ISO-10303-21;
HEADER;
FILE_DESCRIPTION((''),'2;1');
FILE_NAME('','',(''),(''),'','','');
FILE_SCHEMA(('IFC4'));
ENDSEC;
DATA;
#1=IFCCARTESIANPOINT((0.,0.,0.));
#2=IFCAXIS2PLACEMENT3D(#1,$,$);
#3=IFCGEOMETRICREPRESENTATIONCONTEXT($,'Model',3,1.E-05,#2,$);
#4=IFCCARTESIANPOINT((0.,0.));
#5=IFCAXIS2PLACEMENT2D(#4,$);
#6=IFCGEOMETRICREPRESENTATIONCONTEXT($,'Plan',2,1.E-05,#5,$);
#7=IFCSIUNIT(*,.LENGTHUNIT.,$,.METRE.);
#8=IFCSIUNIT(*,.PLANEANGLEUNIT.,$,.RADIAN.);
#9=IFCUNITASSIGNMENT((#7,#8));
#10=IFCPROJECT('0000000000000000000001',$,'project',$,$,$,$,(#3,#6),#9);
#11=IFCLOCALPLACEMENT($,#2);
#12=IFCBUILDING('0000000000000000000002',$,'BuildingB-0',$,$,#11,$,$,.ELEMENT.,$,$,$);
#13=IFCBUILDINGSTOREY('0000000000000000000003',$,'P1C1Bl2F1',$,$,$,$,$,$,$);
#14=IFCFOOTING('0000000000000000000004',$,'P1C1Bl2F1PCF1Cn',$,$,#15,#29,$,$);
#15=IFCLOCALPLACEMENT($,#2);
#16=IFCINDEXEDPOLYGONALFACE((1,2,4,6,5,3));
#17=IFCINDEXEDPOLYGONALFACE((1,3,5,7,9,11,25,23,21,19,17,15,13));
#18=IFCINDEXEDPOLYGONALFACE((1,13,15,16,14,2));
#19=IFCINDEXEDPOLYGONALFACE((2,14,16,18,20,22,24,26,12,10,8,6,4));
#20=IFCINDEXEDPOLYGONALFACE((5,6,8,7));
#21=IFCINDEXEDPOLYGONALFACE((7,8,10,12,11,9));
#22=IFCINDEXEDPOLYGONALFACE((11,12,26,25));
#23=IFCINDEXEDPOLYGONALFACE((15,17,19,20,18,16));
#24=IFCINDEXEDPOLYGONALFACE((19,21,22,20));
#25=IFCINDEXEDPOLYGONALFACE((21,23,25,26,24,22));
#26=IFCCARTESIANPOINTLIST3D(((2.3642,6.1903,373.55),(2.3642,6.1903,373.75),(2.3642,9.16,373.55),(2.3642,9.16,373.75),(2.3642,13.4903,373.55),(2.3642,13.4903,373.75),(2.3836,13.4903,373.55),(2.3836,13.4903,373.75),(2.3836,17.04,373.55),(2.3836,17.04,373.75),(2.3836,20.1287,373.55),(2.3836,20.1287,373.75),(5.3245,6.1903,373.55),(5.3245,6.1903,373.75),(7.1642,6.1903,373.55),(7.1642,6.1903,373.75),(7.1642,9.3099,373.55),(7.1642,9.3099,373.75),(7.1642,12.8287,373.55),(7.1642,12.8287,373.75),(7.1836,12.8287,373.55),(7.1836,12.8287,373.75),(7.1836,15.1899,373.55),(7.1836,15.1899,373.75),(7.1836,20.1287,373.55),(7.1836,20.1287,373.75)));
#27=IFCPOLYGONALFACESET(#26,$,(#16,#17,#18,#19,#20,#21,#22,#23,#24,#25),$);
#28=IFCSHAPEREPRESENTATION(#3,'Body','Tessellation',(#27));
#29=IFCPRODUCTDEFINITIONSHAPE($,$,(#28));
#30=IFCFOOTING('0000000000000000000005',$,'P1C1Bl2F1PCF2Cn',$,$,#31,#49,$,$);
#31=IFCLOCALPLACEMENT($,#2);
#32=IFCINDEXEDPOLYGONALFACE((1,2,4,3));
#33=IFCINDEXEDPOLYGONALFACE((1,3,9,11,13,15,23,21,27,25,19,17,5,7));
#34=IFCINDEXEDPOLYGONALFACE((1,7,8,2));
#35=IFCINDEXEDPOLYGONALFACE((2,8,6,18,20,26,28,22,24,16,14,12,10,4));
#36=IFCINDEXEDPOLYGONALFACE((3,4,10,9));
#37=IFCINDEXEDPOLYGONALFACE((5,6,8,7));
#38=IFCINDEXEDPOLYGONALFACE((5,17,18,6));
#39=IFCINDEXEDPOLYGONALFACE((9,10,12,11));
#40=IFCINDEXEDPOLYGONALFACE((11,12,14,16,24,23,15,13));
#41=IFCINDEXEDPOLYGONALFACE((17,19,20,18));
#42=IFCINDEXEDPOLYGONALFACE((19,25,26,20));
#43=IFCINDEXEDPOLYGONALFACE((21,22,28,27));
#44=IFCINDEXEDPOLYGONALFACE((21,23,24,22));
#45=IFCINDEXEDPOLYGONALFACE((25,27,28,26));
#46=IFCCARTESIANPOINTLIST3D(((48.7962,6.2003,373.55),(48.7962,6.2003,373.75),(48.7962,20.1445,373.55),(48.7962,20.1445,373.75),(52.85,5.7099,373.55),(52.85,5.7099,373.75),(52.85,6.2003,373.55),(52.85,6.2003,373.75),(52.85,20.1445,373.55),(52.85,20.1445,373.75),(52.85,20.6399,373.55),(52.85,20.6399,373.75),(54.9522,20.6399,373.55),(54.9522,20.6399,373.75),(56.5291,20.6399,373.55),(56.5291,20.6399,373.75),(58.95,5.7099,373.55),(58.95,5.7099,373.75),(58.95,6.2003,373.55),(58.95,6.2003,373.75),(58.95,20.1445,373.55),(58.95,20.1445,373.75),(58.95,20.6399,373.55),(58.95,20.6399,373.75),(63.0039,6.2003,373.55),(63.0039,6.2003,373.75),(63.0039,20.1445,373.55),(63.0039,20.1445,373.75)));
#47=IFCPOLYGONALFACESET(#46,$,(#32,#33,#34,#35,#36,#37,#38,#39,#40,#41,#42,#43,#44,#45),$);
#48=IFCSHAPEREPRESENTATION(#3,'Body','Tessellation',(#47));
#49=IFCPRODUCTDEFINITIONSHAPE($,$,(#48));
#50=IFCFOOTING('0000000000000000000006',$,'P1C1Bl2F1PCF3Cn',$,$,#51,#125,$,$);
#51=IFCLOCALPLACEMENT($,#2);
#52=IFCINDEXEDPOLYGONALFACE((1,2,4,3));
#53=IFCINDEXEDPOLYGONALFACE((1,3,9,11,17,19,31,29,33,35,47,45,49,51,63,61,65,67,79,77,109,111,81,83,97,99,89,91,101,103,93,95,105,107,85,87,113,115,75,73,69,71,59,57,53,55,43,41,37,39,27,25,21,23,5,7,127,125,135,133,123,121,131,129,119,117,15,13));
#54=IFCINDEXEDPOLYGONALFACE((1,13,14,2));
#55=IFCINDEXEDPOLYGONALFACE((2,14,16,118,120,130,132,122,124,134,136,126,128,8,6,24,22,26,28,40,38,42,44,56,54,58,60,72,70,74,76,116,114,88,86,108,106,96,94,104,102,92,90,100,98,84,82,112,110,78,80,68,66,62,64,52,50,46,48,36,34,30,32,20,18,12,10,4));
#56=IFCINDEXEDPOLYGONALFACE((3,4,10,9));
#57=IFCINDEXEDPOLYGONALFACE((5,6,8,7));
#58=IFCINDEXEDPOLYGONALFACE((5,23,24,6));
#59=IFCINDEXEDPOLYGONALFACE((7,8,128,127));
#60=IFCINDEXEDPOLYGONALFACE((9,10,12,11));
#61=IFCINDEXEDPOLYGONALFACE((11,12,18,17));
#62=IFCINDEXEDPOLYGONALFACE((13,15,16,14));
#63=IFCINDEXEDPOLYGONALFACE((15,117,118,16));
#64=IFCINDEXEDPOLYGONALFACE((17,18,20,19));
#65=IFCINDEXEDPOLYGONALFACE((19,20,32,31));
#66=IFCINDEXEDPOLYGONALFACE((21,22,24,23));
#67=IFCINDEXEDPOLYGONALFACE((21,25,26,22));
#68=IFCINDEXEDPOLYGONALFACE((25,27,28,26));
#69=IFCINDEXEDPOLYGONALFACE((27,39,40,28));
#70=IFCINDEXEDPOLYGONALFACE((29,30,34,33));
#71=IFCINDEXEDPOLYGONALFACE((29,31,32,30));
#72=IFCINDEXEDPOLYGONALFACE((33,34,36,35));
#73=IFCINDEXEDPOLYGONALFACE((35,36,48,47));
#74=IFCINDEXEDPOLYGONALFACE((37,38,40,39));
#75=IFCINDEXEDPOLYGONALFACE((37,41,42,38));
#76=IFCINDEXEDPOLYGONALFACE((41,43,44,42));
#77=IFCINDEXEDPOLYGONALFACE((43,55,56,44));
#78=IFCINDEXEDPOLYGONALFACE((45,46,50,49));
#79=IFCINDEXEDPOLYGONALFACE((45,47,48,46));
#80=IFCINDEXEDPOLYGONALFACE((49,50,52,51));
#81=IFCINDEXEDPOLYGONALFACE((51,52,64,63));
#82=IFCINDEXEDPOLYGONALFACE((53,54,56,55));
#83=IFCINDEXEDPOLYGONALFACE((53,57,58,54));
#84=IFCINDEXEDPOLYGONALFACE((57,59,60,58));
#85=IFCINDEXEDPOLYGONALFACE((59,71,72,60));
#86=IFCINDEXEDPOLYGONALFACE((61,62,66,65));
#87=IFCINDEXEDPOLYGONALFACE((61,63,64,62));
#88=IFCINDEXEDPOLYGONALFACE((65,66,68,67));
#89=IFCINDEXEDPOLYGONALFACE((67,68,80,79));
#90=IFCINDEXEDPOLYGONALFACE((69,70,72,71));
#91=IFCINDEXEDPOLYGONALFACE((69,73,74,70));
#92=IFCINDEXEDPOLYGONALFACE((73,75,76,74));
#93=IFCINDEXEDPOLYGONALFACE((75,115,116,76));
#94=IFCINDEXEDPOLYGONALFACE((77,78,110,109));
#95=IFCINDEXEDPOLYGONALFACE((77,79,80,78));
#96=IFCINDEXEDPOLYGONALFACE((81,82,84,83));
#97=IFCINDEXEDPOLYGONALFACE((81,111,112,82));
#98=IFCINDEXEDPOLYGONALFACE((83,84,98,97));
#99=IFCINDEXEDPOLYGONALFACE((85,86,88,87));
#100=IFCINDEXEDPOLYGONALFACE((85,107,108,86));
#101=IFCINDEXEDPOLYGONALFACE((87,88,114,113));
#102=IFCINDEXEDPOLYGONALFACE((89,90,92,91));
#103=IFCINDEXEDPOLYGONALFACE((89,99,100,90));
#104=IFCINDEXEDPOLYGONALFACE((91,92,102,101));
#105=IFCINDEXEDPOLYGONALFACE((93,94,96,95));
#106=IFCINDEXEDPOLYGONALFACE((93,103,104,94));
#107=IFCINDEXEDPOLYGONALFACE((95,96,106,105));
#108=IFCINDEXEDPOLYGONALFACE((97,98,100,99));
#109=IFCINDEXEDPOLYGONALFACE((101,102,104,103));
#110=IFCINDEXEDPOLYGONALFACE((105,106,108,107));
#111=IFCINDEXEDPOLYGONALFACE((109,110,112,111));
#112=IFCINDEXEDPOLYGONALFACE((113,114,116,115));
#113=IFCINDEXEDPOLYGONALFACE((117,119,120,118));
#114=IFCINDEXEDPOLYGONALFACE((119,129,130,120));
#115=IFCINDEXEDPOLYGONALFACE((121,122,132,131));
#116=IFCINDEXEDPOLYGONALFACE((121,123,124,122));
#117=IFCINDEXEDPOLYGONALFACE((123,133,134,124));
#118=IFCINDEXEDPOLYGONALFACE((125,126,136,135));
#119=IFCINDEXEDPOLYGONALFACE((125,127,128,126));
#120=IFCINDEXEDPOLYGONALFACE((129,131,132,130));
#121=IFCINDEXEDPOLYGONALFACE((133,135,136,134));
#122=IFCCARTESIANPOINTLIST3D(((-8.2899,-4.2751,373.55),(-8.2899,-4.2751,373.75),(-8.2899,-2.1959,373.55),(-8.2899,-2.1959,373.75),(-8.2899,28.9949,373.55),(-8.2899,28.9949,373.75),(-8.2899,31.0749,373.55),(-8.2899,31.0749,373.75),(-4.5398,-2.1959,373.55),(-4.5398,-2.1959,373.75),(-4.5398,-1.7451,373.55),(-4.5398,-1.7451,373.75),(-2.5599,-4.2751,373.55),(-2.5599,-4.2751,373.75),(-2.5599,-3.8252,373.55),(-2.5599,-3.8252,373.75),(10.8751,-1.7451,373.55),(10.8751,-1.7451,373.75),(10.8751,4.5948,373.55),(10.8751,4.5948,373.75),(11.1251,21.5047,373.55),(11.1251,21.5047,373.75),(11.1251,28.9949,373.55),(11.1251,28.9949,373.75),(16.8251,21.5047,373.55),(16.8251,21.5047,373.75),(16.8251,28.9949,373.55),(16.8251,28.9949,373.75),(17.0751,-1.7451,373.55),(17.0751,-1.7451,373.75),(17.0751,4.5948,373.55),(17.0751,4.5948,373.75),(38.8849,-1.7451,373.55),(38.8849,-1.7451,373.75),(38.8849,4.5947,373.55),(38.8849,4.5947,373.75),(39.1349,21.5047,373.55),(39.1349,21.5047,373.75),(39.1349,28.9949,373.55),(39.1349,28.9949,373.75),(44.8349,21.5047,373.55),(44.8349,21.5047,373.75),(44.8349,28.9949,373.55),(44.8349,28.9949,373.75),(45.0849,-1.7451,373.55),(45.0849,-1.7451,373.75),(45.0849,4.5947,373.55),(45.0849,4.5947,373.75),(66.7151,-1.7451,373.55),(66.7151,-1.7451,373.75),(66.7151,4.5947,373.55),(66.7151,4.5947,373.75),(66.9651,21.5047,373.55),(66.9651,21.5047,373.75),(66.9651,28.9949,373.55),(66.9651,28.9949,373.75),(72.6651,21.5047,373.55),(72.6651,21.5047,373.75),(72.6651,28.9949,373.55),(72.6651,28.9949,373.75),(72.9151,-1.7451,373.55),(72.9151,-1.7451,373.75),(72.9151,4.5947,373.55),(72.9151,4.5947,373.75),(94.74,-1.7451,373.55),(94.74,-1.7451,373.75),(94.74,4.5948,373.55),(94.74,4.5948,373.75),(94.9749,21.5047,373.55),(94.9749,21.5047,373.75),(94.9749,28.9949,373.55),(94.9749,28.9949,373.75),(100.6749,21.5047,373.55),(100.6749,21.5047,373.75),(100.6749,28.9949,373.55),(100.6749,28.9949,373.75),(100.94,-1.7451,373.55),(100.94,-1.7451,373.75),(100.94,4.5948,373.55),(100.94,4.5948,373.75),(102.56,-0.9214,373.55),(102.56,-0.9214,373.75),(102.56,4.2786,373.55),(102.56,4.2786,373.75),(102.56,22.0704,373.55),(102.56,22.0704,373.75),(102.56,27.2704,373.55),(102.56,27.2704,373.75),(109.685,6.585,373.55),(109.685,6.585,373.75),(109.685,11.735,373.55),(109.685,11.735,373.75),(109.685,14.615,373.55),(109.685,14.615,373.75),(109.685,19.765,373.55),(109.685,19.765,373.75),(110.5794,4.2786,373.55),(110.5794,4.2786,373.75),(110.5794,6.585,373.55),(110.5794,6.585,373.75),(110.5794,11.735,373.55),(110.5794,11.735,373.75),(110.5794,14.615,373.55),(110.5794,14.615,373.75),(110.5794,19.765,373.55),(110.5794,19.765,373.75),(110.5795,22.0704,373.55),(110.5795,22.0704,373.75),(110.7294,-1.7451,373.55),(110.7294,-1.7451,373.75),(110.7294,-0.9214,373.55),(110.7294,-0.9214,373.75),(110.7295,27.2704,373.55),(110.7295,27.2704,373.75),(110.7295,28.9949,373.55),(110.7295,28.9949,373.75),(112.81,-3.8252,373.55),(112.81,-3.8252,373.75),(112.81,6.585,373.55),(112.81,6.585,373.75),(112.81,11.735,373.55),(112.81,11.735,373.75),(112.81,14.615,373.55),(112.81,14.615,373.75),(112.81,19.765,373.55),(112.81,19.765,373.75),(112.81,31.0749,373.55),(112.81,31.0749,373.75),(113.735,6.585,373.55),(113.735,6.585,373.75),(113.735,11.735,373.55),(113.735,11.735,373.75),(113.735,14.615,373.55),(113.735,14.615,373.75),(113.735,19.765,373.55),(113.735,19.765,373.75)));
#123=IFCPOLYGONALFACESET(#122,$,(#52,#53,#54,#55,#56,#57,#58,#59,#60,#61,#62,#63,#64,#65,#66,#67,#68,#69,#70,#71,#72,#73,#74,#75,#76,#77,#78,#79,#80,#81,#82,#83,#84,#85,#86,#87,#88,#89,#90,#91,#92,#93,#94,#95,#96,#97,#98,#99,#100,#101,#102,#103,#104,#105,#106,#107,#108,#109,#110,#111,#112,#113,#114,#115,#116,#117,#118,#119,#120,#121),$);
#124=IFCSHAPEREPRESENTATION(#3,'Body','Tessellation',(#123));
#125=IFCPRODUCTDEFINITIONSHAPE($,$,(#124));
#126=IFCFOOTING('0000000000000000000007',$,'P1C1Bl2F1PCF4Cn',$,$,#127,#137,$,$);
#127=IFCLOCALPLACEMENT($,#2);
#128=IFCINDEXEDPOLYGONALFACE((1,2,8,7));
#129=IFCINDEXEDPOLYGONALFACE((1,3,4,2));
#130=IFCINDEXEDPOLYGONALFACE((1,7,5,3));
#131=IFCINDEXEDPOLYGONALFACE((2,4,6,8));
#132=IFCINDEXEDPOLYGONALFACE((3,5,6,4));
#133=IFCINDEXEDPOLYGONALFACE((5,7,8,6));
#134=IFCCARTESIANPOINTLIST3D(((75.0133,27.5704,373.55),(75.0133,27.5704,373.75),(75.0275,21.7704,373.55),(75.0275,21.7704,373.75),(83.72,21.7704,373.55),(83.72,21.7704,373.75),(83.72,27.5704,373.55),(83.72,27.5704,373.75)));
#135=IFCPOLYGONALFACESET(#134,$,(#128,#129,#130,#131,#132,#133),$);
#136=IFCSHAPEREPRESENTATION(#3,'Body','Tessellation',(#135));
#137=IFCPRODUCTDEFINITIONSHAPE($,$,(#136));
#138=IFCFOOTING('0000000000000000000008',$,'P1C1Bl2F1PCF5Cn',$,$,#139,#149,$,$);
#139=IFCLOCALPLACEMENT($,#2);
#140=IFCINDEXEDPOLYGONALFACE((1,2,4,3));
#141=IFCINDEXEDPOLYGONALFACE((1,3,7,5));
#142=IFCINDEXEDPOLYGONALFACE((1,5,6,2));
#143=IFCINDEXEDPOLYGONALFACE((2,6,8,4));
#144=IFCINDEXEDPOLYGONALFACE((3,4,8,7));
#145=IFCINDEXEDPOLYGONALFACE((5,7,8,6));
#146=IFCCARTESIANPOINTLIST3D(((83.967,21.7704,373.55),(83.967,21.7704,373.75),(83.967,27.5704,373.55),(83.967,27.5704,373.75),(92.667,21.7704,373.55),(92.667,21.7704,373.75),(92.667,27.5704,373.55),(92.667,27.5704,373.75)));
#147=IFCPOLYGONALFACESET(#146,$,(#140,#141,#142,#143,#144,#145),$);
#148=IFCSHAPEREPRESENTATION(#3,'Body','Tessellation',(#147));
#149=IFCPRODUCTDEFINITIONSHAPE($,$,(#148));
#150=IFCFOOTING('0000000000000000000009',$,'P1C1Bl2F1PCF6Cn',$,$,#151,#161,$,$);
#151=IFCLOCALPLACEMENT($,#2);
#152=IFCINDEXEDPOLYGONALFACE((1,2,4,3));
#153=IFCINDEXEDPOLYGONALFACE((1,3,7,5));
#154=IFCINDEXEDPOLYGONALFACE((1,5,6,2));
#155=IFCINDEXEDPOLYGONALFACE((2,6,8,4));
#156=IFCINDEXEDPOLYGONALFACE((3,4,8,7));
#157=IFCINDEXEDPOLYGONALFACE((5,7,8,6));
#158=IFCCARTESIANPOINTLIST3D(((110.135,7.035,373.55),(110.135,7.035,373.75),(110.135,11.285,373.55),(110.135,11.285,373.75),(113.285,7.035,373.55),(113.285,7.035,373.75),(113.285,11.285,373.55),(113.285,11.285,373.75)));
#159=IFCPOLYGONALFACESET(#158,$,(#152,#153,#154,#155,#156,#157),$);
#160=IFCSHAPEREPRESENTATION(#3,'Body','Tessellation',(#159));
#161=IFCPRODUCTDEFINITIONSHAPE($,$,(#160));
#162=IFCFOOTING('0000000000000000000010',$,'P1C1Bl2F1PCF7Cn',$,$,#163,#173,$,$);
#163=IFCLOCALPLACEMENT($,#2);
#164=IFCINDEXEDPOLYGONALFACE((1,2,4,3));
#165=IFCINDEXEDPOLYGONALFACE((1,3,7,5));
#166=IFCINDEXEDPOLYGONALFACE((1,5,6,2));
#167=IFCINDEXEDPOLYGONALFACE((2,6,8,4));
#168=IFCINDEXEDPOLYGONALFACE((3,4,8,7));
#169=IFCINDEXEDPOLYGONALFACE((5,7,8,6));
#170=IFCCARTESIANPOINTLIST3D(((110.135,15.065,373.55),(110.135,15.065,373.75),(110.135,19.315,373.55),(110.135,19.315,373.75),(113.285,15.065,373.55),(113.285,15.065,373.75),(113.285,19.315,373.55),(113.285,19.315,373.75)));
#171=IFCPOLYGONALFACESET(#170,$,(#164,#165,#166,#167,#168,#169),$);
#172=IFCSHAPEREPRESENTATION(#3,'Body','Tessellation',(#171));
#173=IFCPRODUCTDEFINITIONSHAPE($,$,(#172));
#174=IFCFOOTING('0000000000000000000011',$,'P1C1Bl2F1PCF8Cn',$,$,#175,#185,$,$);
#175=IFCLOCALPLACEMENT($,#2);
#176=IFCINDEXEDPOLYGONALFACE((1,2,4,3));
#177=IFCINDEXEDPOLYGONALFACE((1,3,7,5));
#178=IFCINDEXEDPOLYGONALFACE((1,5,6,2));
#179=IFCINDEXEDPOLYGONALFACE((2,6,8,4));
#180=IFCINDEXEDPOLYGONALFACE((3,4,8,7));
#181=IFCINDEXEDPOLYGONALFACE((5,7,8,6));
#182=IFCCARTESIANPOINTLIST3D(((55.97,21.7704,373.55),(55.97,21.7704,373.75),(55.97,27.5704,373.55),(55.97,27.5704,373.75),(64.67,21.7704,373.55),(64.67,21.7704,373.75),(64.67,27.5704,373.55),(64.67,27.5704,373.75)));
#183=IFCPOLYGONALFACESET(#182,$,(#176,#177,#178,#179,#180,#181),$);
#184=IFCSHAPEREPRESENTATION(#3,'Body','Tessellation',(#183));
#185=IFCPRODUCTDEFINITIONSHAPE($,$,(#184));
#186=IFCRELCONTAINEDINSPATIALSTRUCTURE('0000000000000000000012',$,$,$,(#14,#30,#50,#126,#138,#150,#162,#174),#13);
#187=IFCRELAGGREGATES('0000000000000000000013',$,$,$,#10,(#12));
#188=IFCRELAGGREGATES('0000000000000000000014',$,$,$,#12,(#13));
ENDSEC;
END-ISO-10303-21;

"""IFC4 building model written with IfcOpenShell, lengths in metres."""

from ifc_helpers import new_model, si_unit, origin, origin_2d, place, context, project, spatial, polyline, outline, extrude, element, save


model = new_model("IFC4")

# Units and contexts
model_context = context("Model", 3, precision=1e-05, world=origin())
plan_context = context("Plan", 2, precision=1e-05, world=origin_2d())
ifc_project = project(units=[si_unit("LENGTHUNIT", "METRE"), si_unit("PLANEANGLEUNIT", "RADIAN")], contexts=[model_context, plan_context])

# Building, storey
building_placement = place(None, origin())
building = spatial("IfcBuilding", under=ifc_project, at=building_placement, Name="BuildingB-0", CompositionType="ELEMENT")
storey = spatial("IfcBuildingStorey", under=building, Name="P1C1Bl2F1")

# Footings
element("IfcFooting", 1, inside=storey, Name="P1C1Bl2F1PCF1Cn", context=model_context, shape_type="SweptSolid", body=[
    extrude(outline(polyline([(7.1642, 12.8287, 373.55), (7.1836, 12.8287, 373.55), (7.1836, 15.1899, 373.55), (7.1836, 20.1287, 373.55), (2.3836, 20.1287, 373.55), (2.3836, 17.04, 373.55), (2.3836, 13.4903, 373.55), (2.3642, 13.4903, 373.55), (2.3642, 9.16, 373.55), (2.3642, 6.1903, 373.55), (5.3245, 6.1903, 373.55), (7.1642, 6.1903, 373.55), (7.1642, 9.3099, 373.55), (7.1642, 12.8287, 373.55)])), None, (0.0, 0.0, 1.0), 0.2),
])
element("IfcFooting", 2, inside=storey, Name="P1C1Bl2F1PCF2Cn", context=model_context, shape_type="SweptSolid", body=[
    extrude(outline(polyline([(58.95, 5.7099, 373.55), (58.95, 6.2003, 373.55), (63.0039, 6.2003, 373.55), (63.0039, 20.1445, 373.55), (58.95, 20.1445, 373.55), (58.95, 20.6399, 373.55), (56.5291, 20.6399, 373.55), (54.9522, 20.6399, 373.55), (52.85, 20.6399, 373.55), (52.85, 20.1445, 373.55), (48.7962, 20.1445, 373.55), (48.7962, 6.2003, 373.55), (52.85, 6.2003, 373.55), (52.85, 5.7099, 373.55), (58.95, 5.7099, 373.55)])), None, (0.0, 0.0, 1.0), 0.2),
])
element("IfcFooting", 3, inside=storey, Name="P1C1Bl2F1PCF3Cn", context=model_context, shape_type="SweptSolid", body=[
    extrude(outline(polyline([(-8.2899, 31.0749, 373.55), (-8.2899, 28.9949, 373.55), (11.1251, 28.9949, 373.55), (11.1251, 21.5047, 373.55), (16.8251, 21.5047, 373.55), (16.8251, 28.9949, 373.55), (39.1349, 28.9949, 373.55), (39.1349, 21.5047, 373.55), (44.8349, 21.5047, 373.55), (44.8349, 28.9949, 373.55), (66.9651, 28.9949, 373.55), (66.9651, 21.5047, 373.55), (72.6651, 21.5047, 373.55), (72.6651, 28.9949, 373.55), (94.9749, 28.9949, 373.55), (94.9749, 21.5047, 373.55), (100.6749, 21.5047, 373.55), (100.6749, 28.9949, 373.55), (110.7295, 28.9949, 373.55), (110.7295, 27.2704, 373.55), (102.56, 27.2704, 373.55), (102.56, 22.0704, 373.55), (110.5795, 22.0704, 373.55), (110.5794, 19.765, 373.55), (109.685, 19.765, 373.55), (109.685, 14.615, 373.55), (110.5794, 14.615, 373.55), (110.5794, 11.735, 373.55), (109.685, 11.735, 373.55), (109.685, 6.585, 373.55), (110.5794, 6.585, 373.55), (110.5794, 4.2786, 373.55), (102.56, 4.2786, 373.55), (102.56, -0.9214, 373.55), (110.7294, -0.9214, 373.55), (110.7294, -1.7451, 373.55), (100.94, -1.7451, 373.55), (100.94, 4.5948, 373.55), (94.74, 4.5948, 373.55), (94.74, -1.7451, 373.55), (72.9151, -1.7451, 373.55), (72.9151, 4.5947, 373.55), (66.7151, 4.5947, 373.55), (66.7151, -1.7451, 373.55), (45.0849, -1.7451, 373.55), (45.0849, 4.5947, 373.55), (38.8849, 4.5947, 373.55), (38.8849, -1.7451, 373.55), (17.0751, -1.7451, 373.55), (17.0751, 4.5948, 373.55), (10.8751, 4.5948, 373.55), (10.8751, -1.7451, 373.55), (-4.5398, -1.7451, 373.55), (-4.5398, -2.1959, 373.55), (-8.2899, -2.1959, 373.55), (-8.2899, -4.2751, 373.55), (-2.5599, -4.2751, 373.55), (-2.5599, -3.8252, 373.55), (112.81, -3.8252, 373.55), (112.81, 6.585, 373.55), (113.735, 6.585, 373.55), (113.735, 11.735, 373.55), (112.81, 11.735, 373.55), (112.81, 14.615, 373.55), (113.735, 14.615, 373.55), (113.735, 19.765, 373.55), (112.81, 19.765, 373.55), (112.81, 31.0749, 373.55), (-8.2899, 31.0749, 373.55)])), None, (0.0, 0.0, 1.0), 0.2),
])
element("IfcFooting", 4, inside=storey, Name="P1C1Bl2F1PCF4Cn", context=model_context, shape_type="SweptSolid", body=[
    extrude(outline(polyline([(75.0275, 21.7704, 373.55), (83.72, 21.7704, 373.55), (83.72, 27.5704, 373.55), (75.0133, 27.5704, 373.55), (75.0275, 21.7704, 373.55)])), None, (0.0, 0.0, 1.0), 0.2),
])
element("IfcFooting", 5, inside=storey, Name="P1C1Bl2F1PCF5Cn", context=model_context, shape_type="SweptSolid", body=[
    extrude(outline(polyline([(83.967, 21.7704, 373.55), (92.667, 21.7704, 373.55), (92.667, 27.5704, 373.55), (83.967, 27.5704, 373.55), (83.967, 21.7704, 373.55)])), None, (0.0, 0.0, 1.0), 0.2),
])
element("IfcFooting", 6, inside=storey, Name="P1C1Bl2F1PCF6Cn", context=model_context, shape_type="SweptSolid", body=[
    extrude(outline(polyline([(110.135, 11.285, 373.55), (113.285, 11.285, 373.55), (113.285, 7.035, 373.55), (110.135, 7.035, 373.55), (110.135, 11.285, 373.55)])), None, (0.0, 0.0, 1.0), 0.2),
])
element("IfcFooting", 7, inside=storey, Name="P1C1Bl2F1PCF7Cn", context=model_context, shape_type="SweptSolid", body=[
    extrude(outline(polyline([(110.135, 19.315, 373.55), (113.285, 19.315, 373.55), (113.285, 15.065, 373.55), (110.135, 15.065, 373.55), (110.135, 19.315, 373.55)])), None, (0.0, 0.0, 1.0), 0.2),
])
element("IfcFooting", 8, inside=storey, Name="P1C1Bl2F1PCF8Cn", context=model_context, shape_type="SweptSolid", body=[
    extrude(outline(polyline([(55.97, 27.5704, 373.55), (64.67, 27.5704, 373.55), (64.67, 21.7704, 373.55), (55.97, 21.7704, 373.55), (55.97, 27.5704, 373.55)])), None, (0.0, 0.0, 1.0), 0.2),
])

save(model, "model.ifc")
